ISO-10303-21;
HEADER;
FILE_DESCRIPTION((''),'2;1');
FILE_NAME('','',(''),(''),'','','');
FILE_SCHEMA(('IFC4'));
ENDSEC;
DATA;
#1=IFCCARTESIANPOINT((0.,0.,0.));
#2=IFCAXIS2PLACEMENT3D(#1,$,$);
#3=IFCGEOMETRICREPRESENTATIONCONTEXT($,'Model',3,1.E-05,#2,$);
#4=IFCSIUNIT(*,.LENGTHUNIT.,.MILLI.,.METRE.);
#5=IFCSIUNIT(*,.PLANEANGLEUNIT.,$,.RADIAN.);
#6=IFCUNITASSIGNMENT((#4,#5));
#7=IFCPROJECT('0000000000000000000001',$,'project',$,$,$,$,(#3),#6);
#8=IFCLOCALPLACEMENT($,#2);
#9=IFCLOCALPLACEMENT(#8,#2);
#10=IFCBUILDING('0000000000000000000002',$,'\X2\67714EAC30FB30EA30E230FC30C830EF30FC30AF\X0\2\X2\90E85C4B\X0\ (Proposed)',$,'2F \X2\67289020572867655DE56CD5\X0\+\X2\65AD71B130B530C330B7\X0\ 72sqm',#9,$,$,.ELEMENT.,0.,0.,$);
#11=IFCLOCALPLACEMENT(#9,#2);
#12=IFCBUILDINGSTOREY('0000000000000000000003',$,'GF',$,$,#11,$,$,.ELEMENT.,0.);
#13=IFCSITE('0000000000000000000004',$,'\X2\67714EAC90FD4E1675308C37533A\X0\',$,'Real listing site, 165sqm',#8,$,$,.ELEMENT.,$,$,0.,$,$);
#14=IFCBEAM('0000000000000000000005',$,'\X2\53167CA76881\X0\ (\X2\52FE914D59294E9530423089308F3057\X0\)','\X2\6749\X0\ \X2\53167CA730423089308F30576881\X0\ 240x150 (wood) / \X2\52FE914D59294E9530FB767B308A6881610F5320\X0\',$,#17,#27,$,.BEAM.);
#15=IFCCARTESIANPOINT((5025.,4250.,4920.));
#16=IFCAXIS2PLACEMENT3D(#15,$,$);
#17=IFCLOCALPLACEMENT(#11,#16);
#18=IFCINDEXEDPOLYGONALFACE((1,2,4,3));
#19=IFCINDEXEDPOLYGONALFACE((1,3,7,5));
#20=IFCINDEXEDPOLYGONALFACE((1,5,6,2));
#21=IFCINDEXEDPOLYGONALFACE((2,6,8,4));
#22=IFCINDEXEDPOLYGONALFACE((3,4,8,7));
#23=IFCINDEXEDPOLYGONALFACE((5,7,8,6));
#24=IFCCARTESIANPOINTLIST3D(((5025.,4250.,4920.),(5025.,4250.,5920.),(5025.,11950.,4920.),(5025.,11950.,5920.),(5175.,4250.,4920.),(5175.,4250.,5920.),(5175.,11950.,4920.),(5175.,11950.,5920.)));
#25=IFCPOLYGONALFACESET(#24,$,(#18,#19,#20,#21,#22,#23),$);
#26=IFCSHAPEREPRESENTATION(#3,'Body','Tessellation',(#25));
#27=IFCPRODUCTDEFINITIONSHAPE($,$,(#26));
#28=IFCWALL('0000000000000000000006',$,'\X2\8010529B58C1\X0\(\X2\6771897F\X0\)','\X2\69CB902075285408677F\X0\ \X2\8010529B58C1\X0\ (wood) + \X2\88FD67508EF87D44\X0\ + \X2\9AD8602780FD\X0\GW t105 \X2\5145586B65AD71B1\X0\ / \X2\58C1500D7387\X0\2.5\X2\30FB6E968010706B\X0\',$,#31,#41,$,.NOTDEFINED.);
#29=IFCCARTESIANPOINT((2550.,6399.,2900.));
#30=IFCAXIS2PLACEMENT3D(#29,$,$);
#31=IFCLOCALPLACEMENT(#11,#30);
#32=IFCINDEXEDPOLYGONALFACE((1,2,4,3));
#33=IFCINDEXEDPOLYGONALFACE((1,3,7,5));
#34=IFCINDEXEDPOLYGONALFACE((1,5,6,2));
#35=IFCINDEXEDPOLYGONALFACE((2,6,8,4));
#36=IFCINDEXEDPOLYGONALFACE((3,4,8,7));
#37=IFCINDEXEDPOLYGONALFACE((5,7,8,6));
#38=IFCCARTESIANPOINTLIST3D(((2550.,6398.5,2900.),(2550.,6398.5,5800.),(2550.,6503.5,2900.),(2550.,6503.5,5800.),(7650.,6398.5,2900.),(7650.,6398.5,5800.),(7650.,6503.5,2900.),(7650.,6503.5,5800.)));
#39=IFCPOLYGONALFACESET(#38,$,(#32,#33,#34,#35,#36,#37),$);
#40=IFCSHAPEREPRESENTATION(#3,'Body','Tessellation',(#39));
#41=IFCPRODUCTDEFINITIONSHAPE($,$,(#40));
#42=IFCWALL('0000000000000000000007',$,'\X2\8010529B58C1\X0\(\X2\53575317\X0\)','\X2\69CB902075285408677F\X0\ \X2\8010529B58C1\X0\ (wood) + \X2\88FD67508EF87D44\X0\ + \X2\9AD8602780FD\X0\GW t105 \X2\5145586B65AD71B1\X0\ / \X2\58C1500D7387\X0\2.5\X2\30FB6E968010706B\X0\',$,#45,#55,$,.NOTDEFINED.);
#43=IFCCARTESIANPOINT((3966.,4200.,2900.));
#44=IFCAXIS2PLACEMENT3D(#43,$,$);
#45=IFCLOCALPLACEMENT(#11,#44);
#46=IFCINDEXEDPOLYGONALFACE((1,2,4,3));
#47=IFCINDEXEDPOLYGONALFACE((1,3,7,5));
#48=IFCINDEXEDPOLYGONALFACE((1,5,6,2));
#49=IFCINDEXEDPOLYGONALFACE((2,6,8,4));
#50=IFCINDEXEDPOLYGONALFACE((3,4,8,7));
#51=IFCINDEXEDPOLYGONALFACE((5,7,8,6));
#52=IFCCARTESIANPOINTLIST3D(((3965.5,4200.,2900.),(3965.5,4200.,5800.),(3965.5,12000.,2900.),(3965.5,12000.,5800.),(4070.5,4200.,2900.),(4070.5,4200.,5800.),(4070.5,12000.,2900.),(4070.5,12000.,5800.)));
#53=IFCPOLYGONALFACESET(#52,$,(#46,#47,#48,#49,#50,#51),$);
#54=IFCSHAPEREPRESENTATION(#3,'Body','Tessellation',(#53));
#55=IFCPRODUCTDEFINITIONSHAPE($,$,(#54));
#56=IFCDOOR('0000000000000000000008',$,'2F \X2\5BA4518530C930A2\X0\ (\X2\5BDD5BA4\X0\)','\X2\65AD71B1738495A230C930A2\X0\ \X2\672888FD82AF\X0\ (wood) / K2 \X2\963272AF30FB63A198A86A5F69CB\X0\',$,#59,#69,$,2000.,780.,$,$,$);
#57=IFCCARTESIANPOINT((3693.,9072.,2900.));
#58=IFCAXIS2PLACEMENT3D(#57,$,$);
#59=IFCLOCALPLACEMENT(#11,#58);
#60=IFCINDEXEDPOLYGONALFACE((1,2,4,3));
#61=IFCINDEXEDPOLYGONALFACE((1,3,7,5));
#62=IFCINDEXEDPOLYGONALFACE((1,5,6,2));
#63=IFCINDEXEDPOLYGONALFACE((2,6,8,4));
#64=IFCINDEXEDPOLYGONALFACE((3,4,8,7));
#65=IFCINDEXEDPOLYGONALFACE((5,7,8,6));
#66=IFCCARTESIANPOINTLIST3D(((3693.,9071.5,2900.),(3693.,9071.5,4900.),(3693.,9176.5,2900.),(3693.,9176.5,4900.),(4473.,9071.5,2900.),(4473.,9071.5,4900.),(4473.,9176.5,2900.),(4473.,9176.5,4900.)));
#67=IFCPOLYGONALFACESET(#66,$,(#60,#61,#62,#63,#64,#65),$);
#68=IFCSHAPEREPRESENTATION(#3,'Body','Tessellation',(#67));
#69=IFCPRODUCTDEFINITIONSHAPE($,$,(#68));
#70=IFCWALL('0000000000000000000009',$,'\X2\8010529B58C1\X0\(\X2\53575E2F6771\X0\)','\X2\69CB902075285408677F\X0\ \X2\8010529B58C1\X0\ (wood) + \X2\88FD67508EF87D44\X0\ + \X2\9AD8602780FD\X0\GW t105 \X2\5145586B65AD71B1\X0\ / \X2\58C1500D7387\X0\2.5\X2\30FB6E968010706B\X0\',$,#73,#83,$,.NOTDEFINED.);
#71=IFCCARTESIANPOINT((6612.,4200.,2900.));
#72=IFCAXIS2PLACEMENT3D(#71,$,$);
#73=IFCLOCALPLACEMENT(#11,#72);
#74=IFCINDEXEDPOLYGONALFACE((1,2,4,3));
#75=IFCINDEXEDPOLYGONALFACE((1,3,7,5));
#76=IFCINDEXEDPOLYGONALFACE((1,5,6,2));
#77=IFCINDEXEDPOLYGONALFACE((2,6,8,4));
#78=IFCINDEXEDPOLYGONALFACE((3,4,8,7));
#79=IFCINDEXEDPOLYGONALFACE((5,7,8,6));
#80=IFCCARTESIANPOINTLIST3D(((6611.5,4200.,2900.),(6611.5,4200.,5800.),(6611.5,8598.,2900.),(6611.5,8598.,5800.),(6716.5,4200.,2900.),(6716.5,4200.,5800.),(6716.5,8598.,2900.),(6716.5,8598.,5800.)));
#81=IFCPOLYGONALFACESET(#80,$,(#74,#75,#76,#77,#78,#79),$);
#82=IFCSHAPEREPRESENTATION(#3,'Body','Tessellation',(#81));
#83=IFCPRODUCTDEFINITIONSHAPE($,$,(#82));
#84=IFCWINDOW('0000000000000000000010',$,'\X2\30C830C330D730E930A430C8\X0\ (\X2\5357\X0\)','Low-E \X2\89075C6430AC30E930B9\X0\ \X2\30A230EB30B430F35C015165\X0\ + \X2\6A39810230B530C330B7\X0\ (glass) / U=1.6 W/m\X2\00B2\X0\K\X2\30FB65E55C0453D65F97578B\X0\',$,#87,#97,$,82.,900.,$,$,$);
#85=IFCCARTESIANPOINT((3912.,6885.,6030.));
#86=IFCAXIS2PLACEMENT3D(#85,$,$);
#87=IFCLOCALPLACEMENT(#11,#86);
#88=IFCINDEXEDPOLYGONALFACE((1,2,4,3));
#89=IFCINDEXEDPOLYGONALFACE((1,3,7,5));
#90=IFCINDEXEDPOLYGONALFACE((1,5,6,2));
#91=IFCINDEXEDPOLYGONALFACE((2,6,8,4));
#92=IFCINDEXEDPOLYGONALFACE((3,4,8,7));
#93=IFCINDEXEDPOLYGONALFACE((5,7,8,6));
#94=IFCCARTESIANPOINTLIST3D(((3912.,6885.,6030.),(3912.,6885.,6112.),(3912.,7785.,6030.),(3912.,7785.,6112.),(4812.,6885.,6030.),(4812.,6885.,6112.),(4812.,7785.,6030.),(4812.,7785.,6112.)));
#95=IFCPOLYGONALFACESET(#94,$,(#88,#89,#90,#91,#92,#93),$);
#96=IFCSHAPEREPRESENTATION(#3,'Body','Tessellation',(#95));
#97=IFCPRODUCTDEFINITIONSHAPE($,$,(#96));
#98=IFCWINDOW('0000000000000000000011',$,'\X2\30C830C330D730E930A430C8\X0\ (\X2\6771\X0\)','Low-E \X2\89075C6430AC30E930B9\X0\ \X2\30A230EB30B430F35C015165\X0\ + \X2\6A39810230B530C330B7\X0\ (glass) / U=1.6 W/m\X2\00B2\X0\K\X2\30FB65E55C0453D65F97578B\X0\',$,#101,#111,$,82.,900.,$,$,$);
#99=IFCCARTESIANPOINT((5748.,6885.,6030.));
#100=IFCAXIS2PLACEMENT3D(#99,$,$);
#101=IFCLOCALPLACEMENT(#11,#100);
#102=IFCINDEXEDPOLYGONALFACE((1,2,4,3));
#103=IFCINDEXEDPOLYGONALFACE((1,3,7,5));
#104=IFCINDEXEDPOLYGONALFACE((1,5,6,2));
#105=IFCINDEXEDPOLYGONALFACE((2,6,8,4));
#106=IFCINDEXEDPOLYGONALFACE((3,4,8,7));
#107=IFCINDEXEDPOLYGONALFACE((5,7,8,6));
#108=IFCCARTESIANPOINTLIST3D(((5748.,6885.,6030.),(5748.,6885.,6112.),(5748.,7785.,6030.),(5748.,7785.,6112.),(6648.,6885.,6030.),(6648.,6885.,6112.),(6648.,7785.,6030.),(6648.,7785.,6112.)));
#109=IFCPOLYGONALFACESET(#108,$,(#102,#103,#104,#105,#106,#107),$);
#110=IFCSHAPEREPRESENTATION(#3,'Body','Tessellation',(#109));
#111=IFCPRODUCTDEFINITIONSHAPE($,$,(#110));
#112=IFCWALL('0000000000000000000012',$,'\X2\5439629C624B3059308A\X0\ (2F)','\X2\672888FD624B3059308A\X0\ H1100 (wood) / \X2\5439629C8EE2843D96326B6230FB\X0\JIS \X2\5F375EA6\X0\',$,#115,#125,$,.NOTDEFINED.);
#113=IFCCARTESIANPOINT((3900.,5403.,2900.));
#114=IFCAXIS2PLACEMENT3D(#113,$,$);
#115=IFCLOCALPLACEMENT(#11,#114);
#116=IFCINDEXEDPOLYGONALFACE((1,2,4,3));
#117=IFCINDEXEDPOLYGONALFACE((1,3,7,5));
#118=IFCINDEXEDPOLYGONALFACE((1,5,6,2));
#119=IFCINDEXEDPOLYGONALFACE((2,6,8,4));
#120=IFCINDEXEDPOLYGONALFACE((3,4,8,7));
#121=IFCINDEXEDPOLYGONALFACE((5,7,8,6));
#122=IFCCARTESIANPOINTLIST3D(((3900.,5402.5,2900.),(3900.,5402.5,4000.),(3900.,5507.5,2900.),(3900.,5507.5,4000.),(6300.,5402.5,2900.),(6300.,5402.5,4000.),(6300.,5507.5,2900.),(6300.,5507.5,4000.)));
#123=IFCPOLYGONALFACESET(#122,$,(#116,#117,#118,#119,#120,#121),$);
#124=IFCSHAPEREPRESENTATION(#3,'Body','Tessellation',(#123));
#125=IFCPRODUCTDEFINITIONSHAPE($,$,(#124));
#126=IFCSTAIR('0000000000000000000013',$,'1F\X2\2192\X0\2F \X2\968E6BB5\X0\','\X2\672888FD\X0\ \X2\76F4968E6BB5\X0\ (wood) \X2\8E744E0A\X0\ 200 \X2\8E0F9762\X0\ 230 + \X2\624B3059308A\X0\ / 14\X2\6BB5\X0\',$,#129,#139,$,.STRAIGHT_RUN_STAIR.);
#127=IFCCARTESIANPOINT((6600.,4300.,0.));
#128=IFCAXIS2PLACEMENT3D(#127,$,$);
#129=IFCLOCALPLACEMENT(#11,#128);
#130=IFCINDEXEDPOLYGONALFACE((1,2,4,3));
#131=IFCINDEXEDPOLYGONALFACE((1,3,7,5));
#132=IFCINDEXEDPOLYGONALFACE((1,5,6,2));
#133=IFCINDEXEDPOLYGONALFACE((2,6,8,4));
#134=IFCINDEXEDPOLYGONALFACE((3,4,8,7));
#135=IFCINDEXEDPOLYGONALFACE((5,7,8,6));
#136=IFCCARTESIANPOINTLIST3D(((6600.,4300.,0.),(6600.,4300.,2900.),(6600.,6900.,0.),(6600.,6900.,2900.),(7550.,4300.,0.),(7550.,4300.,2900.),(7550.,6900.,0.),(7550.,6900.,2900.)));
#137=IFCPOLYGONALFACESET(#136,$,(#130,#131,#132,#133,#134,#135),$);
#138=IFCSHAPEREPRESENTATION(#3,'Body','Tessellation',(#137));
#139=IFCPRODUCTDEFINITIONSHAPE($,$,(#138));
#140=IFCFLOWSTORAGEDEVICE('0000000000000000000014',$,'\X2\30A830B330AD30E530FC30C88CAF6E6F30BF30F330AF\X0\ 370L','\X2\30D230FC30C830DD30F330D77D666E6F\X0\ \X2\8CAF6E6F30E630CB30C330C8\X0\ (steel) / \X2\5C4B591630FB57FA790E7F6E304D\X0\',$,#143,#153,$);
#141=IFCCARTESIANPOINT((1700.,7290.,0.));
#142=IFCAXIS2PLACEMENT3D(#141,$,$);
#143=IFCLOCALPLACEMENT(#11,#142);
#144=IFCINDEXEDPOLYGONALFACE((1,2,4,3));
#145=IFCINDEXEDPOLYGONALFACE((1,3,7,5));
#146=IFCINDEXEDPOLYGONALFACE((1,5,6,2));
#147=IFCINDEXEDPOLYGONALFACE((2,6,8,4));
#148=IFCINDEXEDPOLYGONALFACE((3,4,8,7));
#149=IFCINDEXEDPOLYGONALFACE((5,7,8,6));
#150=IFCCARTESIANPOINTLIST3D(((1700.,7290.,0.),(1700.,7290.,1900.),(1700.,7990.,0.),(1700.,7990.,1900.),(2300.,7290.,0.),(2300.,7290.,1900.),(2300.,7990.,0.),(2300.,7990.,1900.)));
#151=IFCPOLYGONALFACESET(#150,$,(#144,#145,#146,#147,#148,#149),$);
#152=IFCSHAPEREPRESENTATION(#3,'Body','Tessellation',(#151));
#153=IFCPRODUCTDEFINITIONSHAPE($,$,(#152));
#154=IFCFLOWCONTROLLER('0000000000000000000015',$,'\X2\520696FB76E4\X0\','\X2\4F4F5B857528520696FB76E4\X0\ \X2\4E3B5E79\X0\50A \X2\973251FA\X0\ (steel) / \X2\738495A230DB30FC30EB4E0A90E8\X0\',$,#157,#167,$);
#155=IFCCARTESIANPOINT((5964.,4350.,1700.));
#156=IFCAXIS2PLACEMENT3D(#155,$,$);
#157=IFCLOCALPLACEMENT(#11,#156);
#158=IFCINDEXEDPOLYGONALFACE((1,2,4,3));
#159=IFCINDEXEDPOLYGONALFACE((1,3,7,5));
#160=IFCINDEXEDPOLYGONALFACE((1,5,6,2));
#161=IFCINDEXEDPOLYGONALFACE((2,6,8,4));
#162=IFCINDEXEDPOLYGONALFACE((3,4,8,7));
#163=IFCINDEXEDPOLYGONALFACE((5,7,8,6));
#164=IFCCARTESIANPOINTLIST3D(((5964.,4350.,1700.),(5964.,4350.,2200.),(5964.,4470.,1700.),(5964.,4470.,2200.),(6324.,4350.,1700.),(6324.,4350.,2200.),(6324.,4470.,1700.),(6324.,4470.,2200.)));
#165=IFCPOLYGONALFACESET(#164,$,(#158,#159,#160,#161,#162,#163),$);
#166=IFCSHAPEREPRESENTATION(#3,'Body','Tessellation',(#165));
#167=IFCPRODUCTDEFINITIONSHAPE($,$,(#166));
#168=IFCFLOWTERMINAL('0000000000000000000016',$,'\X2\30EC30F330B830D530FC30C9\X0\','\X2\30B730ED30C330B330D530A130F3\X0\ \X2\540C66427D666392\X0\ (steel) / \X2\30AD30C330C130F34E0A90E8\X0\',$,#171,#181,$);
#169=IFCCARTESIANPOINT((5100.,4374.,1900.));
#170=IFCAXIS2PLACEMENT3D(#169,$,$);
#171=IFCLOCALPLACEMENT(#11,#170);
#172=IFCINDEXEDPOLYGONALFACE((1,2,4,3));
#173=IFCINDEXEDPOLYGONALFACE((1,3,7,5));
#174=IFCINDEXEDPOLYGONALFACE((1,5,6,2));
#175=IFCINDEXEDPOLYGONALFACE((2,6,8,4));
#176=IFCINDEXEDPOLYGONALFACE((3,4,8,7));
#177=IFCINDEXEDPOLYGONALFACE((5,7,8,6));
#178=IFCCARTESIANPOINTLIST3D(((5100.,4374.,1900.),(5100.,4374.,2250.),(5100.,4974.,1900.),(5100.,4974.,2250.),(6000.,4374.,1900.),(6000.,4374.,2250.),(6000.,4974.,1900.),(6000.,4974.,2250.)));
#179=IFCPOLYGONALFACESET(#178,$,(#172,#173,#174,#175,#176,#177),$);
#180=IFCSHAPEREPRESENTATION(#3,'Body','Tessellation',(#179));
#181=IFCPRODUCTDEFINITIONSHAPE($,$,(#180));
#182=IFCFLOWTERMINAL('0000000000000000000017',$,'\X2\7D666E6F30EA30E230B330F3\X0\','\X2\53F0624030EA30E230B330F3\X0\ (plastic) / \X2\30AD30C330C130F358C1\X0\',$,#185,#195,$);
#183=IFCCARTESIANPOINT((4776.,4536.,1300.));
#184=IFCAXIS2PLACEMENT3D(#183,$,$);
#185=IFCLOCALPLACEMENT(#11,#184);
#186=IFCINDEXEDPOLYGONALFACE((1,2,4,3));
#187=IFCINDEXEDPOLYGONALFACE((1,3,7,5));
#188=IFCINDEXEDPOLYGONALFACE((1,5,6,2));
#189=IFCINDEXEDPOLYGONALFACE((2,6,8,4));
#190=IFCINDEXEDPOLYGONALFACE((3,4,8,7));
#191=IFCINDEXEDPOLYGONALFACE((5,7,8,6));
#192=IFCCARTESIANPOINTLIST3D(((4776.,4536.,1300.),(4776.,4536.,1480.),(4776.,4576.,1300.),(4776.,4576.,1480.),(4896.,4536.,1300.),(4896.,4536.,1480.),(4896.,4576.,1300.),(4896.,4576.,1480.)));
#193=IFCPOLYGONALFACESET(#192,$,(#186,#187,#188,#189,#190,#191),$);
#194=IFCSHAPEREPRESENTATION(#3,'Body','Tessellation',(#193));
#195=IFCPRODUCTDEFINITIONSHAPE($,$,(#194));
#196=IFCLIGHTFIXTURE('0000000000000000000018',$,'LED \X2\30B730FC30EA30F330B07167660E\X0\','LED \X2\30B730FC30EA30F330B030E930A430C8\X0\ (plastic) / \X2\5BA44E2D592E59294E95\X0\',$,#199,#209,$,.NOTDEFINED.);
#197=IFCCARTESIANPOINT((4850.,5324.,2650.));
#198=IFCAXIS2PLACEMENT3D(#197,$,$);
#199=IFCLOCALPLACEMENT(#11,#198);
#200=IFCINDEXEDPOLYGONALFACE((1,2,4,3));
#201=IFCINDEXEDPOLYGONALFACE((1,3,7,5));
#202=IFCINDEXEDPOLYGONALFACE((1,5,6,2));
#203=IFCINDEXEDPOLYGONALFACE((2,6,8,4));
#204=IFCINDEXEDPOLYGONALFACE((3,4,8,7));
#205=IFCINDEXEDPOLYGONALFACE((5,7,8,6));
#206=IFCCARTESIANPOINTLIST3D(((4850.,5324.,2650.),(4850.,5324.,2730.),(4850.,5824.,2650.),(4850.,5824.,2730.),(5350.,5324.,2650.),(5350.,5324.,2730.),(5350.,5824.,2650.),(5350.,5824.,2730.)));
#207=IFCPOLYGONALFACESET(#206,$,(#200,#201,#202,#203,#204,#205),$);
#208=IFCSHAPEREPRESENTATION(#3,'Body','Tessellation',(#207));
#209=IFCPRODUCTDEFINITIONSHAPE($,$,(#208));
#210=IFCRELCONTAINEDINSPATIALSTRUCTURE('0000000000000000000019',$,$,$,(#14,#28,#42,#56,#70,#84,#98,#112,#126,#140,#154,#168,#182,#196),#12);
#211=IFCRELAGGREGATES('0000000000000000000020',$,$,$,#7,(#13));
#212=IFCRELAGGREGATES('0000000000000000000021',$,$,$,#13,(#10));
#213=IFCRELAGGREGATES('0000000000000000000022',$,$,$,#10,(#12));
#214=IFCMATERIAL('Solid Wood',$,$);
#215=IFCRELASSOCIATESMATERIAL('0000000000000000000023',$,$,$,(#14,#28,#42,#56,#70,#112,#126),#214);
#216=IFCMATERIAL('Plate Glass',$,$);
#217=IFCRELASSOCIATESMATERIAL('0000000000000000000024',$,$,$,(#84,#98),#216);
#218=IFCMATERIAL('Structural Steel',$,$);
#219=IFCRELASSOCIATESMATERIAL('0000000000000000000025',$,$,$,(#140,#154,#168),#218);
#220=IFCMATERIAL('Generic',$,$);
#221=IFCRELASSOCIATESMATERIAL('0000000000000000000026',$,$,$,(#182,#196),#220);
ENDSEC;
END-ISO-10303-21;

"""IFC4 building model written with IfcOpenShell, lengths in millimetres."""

from ifc_helpers import new_model, si_unit, frame, frame_2d, origin, place, context, project, spatial, rectangle, extrude, material, element, fill, save


model = new_model("IFC4")

# Units and contexts
model_context = context("Model", 3, precision=1e-05, world=origin())
ifc_project = project(units=[si_unit("LENGTHUNIT", "METRE", prefix="MILLI"), si_unit("PLANEANGLEUNIT", "RADIAN")], contexts=[model_context])

# Site, building, storey
site_placement = place(None, origin())
site = spatial("IfcSite", under=ifc_project, at=site_placement, Name="東京都世田谷区", ObjectType="Real listing site, 165sqm", CompositionType="ELEMENT", RefElevation=0.0)
building_placement = place(site_placement, origin())
building = spatial("IfcBuilding", under=site, at=building_placement, Name="東京・リモートワーク2部屋 (Proposed)", ObjectType="2F 木造在来工法+断熱サッシ 72sqm", CompositionType="ELEMENT", ElevationOfRefHeight=0.0, ElevationOfTerrain=0.0)
storey_placement = place(building_placement, origin())
storey = spatial("IfcBuildingStorey", under=building, at=storey_placement, Name="GF", CompositionType="ELEMENT", Elevation=0.0)

# Shared definitions
ifc_material_1 = material(Name="Solid Wood")

# Beam
beam_placement = place(storey_placement, frame((5025.0, 4250.0, 4920.0)))
element("IfcBeam", 1, at=beam_placement, inside=storey, material=ifc_material_1, Name="化粧梁 (勾配天井あらわし)", Description="杉 化粧あらわし梁 240x150 (wood) / 勾配天井・登り梁意匠", PredefinedType="BEAM", context=model_context, shape_type="SweptSolid", body=[
    extrude(rectangle(XDim=150.0, YDim=7700.0, at=frame_2d((75.0, 3850.0))), frame((5025.0, 4250.0, 4920.0)), (0.0, 0.0, 1.0), 1000.0),
])

# Wall
wall_1_placement = place(storey_placement, frame((2550.0, 6399.0, 2900.0)))
element("IfcWall", 2, at=wall_1_placement, inside=storey, material=ifc_material_1, Name="耐力壁(東西)", Description="構造用合板 耐力壁 (wood) + 製材軸組 + 高性能GW t105 充填断熱 / 壁倍率2.5・準耐火", PredefinedType="NOTDEFINED", context=model_context, shape_type="SweptSolid", body=[
    extrude(rectangle(XDim=5100.0, YDim=105.0, at=frame_2d((2550.0, 52.0))), frame((2550.0, 6399.0, 2900.0)), (0.0, 0.0, 1.0), 2900.0),
])

# Wall, opening, door
wall_2_placement = place(storey_placement, frame((3966.0, 4200.0, 2900.0)))
wall_2 = element("IfcWall", 3, at=wall_2_placement, inside=storey, material=ifc_material_1, Name="耐力壁(南北)", Description="構造用合板 耐力壁 (wood) + 製材軸組 + 高性能GW t105 充填断熱 / 壁倍率2.5・準耐火", PredefinedType="NOTDEFINED", context=model_context, shape_type="SweptSolid", body=[
    extrude(rectangle(XDim=105.0, YDim=7800.0, at=frame_2d((52.0, 3900.0))), frame((3966.0, 4200.0, 2900.0)), (0.0, 0.0, 1.0), 2900.0),
])
opening_placement = place(storey_placement, frame((3693.0, 9072.0, 2900.0)))
opening = element("IfcOpeningElement", 4, at=opening_placement, cuts=wall_2, PredefinedType="NOTDEFINED", context=model_context, shape_type="SweptSolid", body=[
    extrude(rectangle(XDim=780.0, YDim=105.0, at=frame_2d((390.0, 52.0))), frame((3693.0, 9072.0, 2900.0)), (0.0, 0.0, 1.0), 2000.0),
])
door_placement = place(storey_placement, frame((3693.0, 9072.0, 2900.0)))
door = element("IfcDoor", 5, at=door_placement, inside=storey, material=ifc_material_1, Name="2F 室内ドア (寝室)", Description="断熱玄関ドア 木製芯 (wood) / K2 防犯・採風機構", OverallHeight=2000.0, OverallWidth=780.0, context=model_context, shape_type="SweptSolid", body=[
    extrude(rectangle(XDim=780.0, YDim=105.0, at=frame_2d((390.0, 52.0))), frame((3693.0, 9072.0, 2900.0)), (0.0, 0.0, 1.0), 2000.0),
])
fill(opening, door)

# Wall
wall_3_placement = place(storey_placement, frame((6612.0, 4200.0, 2900.0)))
element("IfcWall", 6, at=wall_3_placement, inside=storey, material=ifc_material_1, Name="耐力壁(南帯東)", Description="構造用合板 耐力壁 (wood) + 製材軸組 + 高性能GW t105 充填断熱 / 壁倍率2.5・準耐火", PredefinedType="NOTDEFINED", context=model_context, shape_type="SweptSolid", body=[
    extrude(rectangle(XDim=105.0, YDim=4398.0, at=frame_2d((52.0, 2199.0))), frame((6612.0, 4200.0, 2900.0)), (0.0, 0.0, 1.0), 2900.0),
])

# Windows
ifc_material_2 = material(Name="Plate Glass")
window_1_placement = place(storey_placement, frame((3912.0, 6885.0, 6030.0)))
element("IfcWindow", 7, at=window_1_placement, inside=storey, material=ifc_material_2, Name="トップライト (南)", Description="Low-E 複層ガラス アルゴン封入 + 樹脂サッシ (glass) / U=1.6 W/m²K・日射取得型", OverallHeight=82.0, OverallWidth=900.0, context=model_context, shape_type="SweptSolid", body=[
    extrude(rectangle(XDim=900.0, YDim=900.0, at=frame_2d((450.0, 450.0))), frame((3912.0, 6885.0, 6030.0)), (0.0, 0.0, 1.0), 82.0),
])
window_2_placement = place(storey_placement, frame((5748.0, 6885.0, 6030.0)))
element("IfcWindow", 8, at=window_2_placement, inside=storey, material=ifc_material_2, Name="トップライト (東)", Description="Low-E 複層ガラス アルゴン封入 + 樹脂サッシ (glass) / U=1.6 W/m²K・日射取得型", OverallHeight=82.0, OverallWidth=900.0, context=model_context, shape_type="SweptSolid", body=[
    extrude(rectangle(XDim=900.0, YDim=900.0, at=frame_2d((450.0, 450.0))), frame((5748.0, 6885.0, 6030.0)), (0.0, 0.0, 1.0), 82.0),
])

# Wall
wall_4_placement = place(storey_placement, frame((3900.0, 5403.0, 2900.0)))
element("IfcWall", 9, at=wall_4_placement, inside=storey, material=ifc_material_1, Name="吹抜手すり (2F)", Description="木製手すり H1100 (wood) / 吹抜転落防止・JIS 強度", PredefinedType="NOTDEFINED", context=model_context, shape_type="SweptSolid", body=[
    extrude(rectangle(XDim=2400.0, YDim=105.0, at=frame_2d((1200.0, 52.0))), frame((3900.0, 5403.0, 2900.0)), (0.0, 0.0, 1.0), 1100.0),
])

# Stair
stair_placement = place(storey_placement, frame((6600.0, 4300.0, 0.0)))
element("IfcStair", 10, at=stair_placement, inside=storey, material=ifc_material_1, Name="1F→2F 階段", Description="木製 直階段 (wood) 蹴上 200 踏面 230 + 手すり / 14段", PredefinedType="STRAIGHT_RUN_STAIR", context=model_context, shape_type="SweptSolid", body=[
    extrude(rectangle(XDim=950.0, YDim=2600.0, at=frame_2d((475.0, 1300.0))), frame((6600.0, 4300.0, 0.0)), (0.0, 0.0, 1.0), 2900.0),
])

# Flow storage device
ifc_material_3 = material(Name="Structural Steel")
flow_storage_device_placement = place(storey_placement, frame((1700.0, 7290.0, 0.0)))
element("IfcFlowStorageDevice", 11, at=flow_storage_device_placement, inside=storey, material=ifc_material_3, Name="エコキュート貯湯タンク 370L", Description="ヒートポンプ給湯 貯湯ユニット (steel) / 屋外・基礎置き", context=model_context, shape_type="SweptSolid", body=[
    extrude(rectangle(XDim=600.0, YDim=700.0, at=frame_2d((300.0, 350.0))), frame((1700.0, 7290.0, 0.0)), (0.0, 0.0, 1.0), 1900.0),
])

# Flow controller
flow_controller_placement = place(storey_placement, frame((5964.0, 4350.0, 1700.0)))
element("IfcFlowController", 12, at=flow_controller_placement, inside=storey, material=ifc_material_3, Name="分電盤", Description="住宅用分電盤 主幹50A 露出 (steel) / 玄関ホール上部", context=model_context, shape_type="SweptSolid", body=[
    extrude(rectangle(XDim=360.0, YDim=120.0, at=frame_2d((180.0, 60.0))), frame((5964.0, 4350.0, 1700.0)), (0.0, 0.0, 1.0), 500.0),
])

# Flow terminals
flow_terminal_1_placement = place(storey_placement, frame((5100.0, 4374.0, 1900.0)))
element("IfcFlowTerminal", 13, at=flow_terminal_1_placement, inside=storey, material=ifc_material_3, Name="レンジフード", Description="シロッコファン 同時給排 (steel) / キッチン上部", context=model_context, shape_type="SweptSolid", body=[
    extrude(rectangle(XDim=900.0, YDim=600.0, at=frame_2d((450.0, 300.0))), frame((5100.0, 4374.0, 1900.0)), (0.0, 0.0, 1.0), 350.0),
])
ifc_material_4 = material(Name="Generic")
flow_terminal_2_placement = place(storey_placement, frame((4776.0, 4536.0, 1300.0)))
element("IfcFlowTerminal", 14, at=flow_terminal_2_placement, inside=storey, material=ifc_material_4, Name="給湯リモコン", Description="台所リモコン (plastic) / キッチン壁", context=model_context, shape_type="SweptSolid", body=[
    extrude(rectangle(XDim=120.0, YDim=40.0, at=frame_2d((60.0, 20.0))), frame((4776.0, 4536.0, 1300.0)), (0.0, 0.0, 1.0), 180.0),
])

# Light fixture
light_fixture_1_placement = place(storey_placement, frame((4850.0, 5324.0, 2650.0)))
element("IfcLightFixture", 15, at=light_fixture_1_placement, inside=storey, material=ifc_material_4, Name="LED シーリング照明", Description="LED シーリングライト (plastic) / 室中央天井", PredefinedType="NOTDEFINED", context=model_context, shape_type="SweptSolid", body=[
    extrude(rectangle(XDim=500.0, YDim=500.0, at=frame_2d((250.0, 250.0))), frame((4850.0, 5324.0, 2650.0)), (0.0, 0.0, 1.0), 80.0),
])

save(model, "model.ifc")
